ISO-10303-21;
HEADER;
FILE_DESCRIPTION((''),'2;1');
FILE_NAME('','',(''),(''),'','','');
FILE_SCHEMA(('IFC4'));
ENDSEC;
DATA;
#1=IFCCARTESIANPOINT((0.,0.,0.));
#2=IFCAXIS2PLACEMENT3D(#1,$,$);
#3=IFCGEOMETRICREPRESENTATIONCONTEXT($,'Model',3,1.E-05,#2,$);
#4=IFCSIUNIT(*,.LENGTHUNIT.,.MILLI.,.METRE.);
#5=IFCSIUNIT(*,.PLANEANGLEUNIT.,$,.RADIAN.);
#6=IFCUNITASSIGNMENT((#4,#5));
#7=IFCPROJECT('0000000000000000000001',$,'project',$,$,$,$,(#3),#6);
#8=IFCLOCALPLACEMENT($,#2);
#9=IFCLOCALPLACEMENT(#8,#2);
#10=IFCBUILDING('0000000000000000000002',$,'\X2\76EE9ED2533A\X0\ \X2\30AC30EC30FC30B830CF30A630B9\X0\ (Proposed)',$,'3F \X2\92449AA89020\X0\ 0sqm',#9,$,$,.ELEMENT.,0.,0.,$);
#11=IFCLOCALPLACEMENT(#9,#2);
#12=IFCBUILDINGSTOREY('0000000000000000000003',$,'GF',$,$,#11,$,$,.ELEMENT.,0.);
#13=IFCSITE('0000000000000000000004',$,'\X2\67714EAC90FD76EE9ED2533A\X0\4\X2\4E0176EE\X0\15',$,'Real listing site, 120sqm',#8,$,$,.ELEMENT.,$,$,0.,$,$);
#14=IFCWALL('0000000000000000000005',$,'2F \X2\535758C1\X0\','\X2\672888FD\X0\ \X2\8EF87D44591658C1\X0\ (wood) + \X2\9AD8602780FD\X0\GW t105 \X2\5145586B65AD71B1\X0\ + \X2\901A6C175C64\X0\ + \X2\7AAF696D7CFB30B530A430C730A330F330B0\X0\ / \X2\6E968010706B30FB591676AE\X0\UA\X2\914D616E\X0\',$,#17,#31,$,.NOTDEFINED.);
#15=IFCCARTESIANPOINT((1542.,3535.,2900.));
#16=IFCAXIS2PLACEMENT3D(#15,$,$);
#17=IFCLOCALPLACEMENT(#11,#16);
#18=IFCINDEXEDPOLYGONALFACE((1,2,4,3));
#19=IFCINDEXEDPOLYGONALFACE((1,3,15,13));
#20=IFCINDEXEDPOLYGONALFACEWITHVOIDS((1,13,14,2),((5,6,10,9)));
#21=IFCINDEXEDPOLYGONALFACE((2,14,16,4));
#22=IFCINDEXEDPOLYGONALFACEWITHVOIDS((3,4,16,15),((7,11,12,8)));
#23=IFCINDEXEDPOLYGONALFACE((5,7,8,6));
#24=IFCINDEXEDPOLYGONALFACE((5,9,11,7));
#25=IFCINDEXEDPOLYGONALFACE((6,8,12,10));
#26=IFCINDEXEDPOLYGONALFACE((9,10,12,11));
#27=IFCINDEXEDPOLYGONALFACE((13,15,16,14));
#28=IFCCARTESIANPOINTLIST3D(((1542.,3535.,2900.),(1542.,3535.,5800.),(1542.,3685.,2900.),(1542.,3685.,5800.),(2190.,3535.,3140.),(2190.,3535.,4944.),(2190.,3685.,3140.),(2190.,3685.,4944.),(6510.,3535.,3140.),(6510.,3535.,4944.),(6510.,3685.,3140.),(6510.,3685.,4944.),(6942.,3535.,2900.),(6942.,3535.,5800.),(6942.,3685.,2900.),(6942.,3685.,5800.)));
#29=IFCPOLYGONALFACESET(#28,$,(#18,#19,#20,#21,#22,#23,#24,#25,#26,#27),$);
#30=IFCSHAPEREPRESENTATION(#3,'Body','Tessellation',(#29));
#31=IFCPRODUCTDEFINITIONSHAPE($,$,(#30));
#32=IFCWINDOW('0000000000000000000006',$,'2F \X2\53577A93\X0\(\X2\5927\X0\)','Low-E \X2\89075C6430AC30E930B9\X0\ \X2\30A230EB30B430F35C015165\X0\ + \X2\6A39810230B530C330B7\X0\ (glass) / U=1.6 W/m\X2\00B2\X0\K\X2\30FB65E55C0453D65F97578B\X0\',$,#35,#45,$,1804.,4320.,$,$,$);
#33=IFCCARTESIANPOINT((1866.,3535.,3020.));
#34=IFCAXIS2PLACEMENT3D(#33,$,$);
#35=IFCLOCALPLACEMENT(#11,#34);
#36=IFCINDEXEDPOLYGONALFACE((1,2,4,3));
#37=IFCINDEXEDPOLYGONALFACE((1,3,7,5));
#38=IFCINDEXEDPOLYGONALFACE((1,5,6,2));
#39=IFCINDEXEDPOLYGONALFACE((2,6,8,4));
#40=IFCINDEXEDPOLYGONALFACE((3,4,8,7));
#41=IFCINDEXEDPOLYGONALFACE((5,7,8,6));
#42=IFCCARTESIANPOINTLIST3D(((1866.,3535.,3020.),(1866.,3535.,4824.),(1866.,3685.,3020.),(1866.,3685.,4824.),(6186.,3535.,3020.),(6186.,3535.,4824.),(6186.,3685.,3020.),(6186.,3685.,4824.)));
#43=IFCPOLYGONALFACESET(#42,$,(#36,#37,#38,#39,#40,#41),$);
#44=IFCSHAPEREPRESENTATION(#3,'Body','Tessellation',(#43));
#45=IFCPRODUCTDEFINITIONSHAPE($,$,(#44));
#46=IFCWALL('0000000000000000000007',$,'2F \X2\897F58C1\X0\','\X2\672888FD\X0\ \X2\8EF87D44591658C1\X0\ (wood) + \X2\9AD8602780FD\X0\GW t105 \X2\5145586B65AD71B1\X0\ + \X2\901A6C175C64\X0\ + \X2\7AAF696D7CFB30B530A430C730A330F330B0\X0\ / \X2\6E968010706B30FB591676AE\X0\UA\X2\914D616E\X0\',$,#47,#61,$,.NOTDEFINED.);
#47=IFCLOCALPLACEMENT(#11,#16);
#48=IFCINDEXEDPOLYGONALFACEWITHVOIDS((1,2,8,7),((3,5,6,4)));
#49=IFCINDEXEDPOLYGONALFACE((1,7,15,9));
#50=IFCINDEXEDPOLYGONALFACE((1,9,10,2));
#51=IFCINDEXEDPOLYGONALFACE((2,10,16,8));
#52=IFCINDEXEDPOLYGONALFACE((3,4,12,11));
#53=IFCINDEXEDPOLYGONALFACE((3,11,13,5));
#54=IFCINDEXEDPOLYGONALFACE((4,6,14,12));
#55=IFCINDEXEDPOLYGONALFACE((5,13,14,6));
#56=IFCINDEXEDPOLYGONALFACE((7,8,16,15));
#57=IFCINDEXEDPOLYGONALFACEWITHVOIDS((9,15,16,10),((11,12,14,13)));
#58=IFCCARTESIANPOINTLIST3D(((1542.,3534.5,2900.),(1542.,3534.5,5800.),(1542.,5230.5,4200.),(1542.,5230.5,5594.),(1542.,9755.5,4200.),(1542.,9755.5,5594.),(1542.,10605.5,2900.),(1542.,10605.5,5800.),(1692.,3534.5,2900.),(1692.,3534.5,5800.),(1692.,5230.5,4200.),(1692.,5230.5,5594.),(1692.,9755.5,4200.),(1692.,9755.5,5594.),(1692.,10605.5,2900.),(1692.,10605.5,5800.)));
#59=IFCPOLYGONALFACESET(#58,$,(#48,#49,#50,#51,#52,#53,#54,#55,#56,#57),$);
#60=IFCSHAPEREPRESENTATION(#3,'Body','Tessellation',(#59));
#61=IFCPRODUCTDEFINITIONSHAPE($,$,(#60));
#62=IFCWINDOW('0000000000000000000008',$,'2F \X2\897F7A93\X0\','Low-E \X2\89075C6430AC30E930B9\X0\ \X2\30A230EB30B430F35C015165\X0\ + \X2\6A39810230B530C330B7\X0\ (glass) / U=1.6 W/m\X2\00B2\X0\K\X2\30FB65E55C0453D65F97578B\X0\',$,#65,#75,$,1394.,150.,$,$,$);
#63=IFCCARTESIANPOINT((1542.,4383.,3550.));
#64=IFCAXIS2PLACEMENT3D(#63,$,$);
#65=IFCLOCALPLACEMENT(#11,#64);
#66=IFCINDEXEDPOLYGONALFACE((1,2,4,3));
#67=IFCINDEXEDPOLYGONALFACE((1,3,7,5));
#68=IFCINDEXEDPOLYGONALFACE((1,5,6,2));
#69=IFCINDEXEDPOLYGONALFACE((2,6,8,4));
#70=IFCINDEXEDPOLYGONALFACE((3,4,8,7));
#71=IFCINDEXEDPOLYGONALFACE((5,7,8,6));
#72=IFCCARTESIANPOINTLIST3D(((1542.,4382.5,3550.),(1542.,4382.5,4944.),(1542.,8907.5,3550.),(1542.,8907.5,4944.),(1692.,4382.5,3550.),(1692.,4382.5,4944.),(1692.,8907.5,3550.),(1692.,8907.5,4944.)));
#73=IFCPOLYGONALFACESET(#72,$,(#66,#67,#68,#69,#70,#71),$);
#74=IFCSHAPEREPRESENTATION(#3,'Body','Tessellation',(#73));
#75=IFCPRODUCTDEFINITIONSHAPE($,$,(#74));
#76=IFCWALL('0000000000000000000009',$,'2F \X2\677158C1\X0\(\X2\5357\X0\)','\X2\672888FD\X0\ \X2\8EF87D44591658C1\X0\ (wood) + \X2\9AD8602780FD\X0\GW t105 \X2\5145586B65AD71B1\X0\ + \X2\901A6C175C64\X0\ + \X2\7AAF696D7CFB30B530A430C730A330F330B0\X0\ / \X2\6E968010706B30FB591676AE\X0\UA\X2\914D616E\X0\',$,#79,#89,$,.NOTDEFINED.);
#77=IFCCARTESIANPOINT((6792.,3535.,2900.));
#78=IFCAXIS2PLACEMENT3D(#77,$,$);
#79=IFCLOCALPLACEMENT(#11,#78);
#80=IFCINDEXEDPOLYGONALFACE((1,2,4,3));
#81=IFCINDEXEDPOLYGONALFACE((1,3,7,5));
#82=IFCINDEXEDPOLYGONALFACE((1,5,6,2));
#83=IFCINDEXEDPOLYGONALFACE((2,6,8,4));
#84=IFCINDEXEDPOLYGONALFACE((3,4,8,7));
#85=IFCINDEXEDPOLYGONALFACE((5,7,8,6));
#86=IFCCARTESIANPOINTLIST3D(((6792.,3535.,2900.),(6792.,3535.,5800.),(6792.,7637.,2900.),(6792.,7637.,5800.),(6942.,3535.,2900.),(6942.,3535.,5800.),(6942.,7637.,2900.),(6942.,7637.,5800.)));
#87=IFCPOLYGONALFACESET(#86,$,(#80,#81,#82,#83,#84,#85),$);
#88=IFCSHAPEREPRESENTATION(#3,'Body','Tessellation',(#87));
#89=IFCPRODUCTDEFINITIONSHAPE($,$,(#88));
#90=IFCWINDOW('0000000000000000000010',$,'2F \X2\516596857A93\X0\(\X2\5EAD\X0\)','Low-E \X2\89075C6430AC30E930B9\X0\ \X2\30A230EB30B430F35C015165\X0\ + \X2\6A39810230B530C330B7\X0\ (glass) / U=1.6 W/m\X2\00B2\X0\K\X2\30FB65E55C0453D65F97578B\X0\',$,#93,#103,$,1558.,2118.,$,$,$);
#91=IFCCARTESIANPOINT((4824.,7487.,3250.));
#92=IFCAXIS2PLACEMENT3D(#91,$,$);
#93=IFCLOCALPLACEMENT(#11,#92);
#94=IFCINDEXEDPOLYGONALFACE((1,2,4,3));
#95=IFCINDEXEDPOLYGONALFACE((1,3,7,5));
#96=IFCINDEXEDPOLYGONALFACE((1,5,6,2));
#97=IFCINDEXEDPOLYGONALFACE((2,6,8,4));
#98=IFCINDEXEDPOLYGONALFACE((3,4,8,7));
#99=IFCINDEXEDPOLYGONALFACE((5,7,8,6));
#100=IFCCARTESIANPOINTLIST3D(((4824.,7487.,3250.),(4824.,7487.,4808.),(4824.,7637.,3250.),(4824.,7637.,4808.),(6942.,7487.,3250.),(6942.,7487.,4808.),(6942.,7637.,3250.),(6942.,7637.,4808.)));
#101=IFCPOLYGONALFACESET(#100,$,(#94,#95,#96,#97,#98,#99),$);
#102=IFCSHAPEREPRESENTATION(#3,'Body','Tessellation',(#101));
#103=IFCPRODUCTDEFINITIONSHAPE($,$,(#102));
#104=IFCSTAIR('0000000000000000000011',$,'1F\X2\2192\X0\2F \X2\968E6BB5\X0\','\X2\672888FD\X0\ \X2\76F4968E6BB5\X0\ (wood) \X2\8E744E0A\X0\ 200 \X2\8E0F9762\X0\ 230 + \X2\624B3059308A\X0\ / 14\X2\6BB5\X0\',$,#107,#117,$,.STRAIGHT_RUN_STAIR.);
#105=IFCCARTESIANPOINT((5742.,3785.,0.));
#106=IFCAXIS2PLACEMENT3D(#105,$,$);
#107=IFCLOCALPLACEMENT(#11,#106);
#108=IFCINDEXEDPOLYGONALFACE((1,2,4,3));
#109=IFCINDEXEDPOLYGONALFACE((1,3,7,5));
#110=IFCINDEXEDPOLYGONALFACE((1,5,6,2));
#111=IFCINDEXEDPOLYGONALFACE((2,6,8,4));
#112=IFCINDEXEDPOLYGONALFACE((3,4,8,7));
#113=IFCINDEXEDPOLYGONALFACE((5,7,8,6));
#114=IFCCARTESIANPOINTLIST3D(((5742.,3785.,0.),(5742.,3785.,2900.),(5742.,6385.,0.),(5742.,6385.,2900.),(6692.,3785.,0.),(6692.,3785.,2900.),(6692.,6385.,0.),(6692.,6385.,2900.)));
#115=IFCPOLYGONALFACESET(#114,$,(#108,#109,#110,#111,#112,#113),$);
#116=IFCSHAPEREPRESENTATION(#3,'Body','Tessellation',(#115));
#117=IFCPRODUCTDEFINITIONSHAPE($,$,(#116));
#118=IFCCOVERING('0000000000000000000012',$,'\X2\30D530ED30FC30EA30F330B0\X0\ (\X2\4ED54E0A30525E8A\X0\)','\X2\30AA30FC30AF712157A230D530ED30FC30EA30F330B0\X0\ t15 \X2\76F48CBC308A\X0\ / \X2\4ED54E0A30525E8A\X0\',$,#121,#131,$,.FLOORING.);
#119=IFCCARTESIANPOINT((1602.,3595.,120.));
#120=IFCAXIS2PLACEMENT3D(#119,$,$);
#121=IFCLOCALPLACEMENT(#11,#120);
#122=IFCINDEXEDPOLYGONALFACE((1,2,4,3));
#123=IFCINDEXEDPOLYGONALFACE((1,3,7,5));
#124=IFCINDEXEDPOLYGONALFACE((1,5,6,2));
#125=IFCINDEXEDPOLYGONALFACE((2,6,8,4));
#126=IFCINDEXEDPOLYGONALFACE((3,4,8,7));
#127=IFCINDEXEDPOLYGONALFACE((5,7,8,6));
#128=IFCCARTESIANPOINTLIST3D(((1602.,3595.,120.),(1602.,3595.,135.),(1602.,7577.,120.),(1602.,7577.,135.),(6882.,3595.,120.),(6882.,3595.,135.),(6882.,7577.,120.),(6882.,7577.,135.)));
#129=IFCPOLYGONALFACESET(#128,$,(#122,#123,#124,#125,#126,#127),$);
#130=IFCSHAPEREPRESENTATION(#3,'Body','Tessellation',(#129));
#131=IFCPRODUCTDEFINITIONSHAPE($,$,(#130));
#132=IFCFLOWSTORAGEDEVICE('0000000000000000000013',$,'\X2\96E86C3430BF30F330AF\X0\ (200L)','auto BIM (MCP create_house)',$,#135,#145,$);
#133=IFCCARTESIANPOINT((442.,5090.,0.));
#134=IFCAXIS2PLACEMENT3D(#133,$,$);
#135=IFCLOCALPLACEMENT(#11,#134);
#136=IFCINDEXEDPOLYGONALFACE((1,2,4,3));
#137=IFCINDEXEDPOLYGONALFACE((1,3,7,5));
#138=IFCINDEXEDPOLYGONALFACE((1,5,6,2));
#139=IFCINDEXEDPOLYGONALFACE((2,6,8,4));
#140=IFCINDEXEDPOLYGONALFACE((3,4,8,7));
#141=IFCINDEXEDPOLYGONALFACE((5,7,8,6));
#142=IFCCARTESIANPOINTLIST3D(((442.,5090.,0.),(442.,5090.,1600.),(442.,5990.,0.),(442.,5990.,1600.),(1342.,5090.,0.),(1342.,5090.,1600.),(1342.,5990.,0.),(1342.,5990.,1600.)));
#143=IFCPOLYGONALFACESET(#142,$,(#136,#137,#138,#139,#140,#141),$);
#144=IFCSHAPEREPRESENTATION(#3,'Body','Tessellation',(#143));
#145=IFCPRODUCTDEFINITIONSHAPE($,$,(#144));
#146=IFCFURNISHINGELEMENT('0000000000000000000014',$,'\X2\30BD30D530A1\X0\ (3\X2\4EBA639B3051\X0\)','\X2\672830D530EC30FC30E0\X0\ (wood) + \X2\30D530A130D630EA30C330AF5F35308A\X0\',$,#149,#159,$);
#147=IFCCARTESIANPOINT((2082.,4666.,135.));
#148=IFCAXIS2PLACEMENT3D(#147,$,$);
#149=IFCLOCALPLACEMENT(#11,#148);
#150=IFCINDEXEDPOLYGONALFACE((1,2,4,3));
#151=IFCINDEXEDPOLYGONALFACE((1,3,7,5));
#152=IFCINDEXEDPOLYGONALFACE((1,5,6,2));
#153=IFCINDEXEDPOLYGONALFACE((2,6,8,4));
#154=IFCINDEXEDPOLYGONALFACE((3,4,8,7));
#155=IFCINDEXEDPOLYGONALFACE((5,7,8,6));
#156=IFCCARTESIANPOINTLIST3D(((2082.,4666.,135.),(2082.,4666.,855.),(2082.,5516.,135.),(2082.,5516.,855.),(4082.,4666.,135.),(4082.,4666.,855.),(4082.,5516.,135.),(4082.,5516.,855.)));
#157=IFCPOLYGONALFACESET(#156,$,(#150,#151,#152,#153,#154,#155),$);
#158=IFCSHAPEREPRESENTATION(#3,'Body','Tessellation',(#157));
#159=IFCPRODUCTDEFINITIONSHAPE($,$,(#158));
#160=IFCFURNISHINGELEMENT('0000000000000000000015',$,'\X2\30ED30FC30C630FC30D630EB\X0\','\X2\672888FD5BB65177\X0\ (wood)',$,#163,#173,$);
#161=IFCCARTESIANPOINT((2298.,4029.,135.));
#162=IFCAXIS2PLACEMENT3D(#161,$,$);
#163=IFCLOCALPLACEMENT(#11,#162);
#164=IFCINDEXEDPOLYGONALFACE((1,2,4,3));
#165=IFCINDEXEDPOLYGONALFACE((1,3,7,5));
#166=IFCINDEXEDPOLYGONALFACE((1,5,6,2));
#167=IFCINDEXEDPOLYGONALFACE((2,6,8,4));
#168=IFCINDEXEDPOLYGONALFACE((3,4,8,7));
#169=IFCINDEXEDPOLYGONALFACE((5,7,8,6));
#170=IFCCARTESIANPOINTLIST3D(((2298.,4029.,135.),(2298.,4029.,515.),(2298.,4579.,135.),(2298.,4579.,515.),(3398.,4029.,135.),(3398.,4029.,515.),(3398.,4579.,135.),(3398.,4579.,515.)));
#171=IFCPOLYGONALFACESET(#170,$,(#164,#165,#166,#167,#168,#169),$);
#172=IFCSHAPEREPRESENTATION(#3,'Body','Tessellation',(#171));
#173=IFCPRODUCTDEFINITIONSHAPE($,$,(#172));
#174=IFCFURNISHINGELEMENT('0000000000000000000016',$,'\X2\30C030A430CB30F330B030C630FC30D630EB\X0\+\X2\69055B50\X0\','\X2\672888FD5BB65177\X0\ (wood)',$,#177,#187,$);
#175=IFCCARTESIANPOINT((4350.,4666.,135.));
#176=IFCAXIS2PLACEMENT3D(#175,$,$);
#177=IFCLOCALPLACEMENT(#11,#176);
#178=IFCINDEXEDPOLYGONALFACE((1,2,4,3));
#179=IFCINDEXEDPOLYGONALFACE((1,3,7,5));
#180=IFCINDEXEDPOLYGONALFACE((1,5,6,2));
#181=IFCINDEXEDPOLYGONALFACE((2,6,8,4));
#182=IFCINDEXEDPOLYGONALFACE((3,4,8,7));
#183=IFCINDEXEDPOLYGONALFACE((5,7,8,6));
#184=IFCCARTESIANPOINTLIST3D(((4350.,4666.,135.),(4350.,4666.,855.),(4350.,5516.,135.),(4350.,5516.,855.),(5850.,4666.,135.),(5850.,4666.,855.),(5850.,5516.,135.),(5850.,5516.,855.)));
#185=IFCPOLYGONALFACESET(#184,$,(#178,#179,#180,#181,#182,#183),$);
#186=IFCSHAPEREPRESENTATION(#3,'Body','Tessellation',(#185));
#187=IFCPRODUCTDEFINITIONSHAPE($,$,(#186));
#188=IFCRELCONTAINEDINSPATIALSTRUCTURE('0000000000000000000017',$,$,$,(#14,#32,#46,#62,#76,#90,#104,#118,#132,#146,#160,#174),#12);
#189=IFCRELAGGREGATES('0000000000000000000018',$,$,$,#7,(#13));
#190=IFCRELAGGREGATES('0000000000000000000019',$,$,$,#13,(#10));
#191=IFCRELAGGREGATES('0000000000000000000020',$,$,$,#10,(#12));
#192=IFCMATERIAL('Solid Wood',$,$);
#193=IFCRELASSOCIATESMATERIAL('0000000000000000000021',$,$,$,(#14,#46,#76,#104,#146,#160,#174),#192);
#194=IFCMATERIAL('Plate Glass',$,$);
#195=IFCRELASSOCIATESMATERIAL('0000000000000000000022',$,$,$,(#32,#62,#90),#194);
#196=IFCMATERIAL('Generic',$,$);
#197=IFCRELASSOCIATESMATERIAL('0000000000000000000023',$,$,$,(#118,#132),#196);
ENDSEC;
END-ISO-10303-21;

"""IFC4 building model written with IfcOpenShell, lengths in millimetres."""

from ifc_helpers import new_model, si_unit, frame, frame_2d, origin, place, context, project, spatial, rectangle, extrude, material, element, fill, save


model = new_model("IFC4")

# Units and contexts
model_context = context("Model", 3, precision=1e-05, world=origin())
ifc_project = project(units=[si_unit("LENGTHUNIT", "METRE", prefix="MILLI"), si_unit("PLANEANGLEUNIT", "RADIAN")], contexts=[model_context])

# Site, building, storey
site_placement = place(None, origin())
site = spatial("IfcSite", under=ifc_project, at=site_placement, Name="東京都目黒区4丁目15", ObjectType="Real listing site, 120sqm", CompositionType="ELEMENT", RefElevation=0.0)
building_placement = place(site_placement, origin())
building = spatial("IfcBuilding", under=site, at=building_placement, Name="目黒区 ガレージハウス (Proposed)", ObjectType="3F 鉄骨造 0sqm", CompositionType="ELEMENT", ElevationOfRefHeight=0.0, ElevationOfTerrain=0.0)
storey_placement = place(building_placement, origin())
storey = spatial("IfcBuildingStorey", under=building, at=storey_placement, Name="GF", CompositionType="ELEMENT", Elevation=0.0)

# Shared definitions
ifc_material_1 = material(Name="Solid Wood")

# Shared definitions
ifc_material_2 = material(Name="Plate Glass")

# Walls, openings, windows
wall_1_placement = place(storey_placement, frame((1542.0, 3535.0, 2900.0)))
wall_1 = element("IfcWall", 1, at=wall_1_placement, inside=storey, material=ifc_material_1, Name="2F 南壁", Description="木製 軸組外壁 (wood) + 高性能GW t105 充填断熱 + 通気層 + 窯業系サイディング / 準耐火・外皮UA配慮", PredefinedType="NOTDEFINED", context=model_context, shape_type="SweptSolid", body=[
    extrude(rectangle(XDim=5400.0, YDim=150.0, at=frame_2d((2700.0, 75.0))), frame((1542.0, 3535.0, 2900.0)), (0.0, 0.0, 1.0), 2900.0),
])
opening_1_placement = place(storey_placement, frame((1866.0, 3535.0, 3020.0)))
opening_1 = element("IfcOpeningElement", 2, at=opening_1_placement, cuts=wall_1, PredefinedType="NOTDEFINED", context=model_context, shape_type="SweptSolid", body=[
    extrude(rectangle(XDim=4320.0, YDim=150.0, at=frame_2d((2160.0, 75.0))), frame((1866.0, 3535.0, 3020.0)), (0.0, 0.0, 1.0), 1804.0),
])
window_1_placement = place(storey_placement, frame((1866.0, 3535.0, 3020.0)))
window_1 = element("IfcWindow", 3, at=window_1_placement, inside=storey, material=ifc_material_2, Name="2F 南窓(大)", Description="Low-E 複層ガラス アルゴン封入 + 樹脂サッシ (glass) / U=1.6 W/m²K・日射取得型", OverallHeight=1804.0, OverallWidth=4320.0, context=model_context, shape_type="SweptSolid", body=[
    extrude(rectangle(XDim=4320.0, YDim=150.0, at=frame_2d((2160.0, 75.0))), frame((1866.0, 3535.0, 3020.0)), (0.0, 0.0, 1.0), 1804.0),
])
fill(opening_1, window_1)
wall_2_placement = place(storey_placement, frame((1542.0, 3535.0, 2900.0)))
wall_2 = element("IfcWall", 4, at=wall_2_placement, inside=storey, material=ifc_material_1, Name="2F 西壁", Description="木製 軸組外壁 (wood) + 高性能GW t105 充填断熱 + 通気層 + 窯業系サイディング / 準耐火・外皮UA配慮", PredefinedType="NOTDEFINED", context=model_context, shape_type="SweptSolid", body=[
    extrude(rectangle(XDim=150.0, YDim=7071.0, at=frame_2d((75.0, 3535.0))), frame((1542.0, 3535.0, 2900.0)), (0.0, 0.0, 1.0), 2900.0),
])
opening_2_placement = place(storey_placement, frame((1542.0, 4383.0, 3550.0)))
opening_2 = element("IfcOpeningElement", 5, at=opening_2_placement, cuts=wall_2, PredefinedType="NOTDEFINED", context=model_context, shape_type="SweptSolid", body=[
    extrude(rectangle(XDim=150.0, YDim=4525.0, at=frame_2d((75.0, 2262.0))), frame((1542.0, 4383.0, 3550.0)), (0.0, 0.0, 1.0), 1394.0),
])
window_2_placement = place(storey_placement, frame((1542.0, 4383.0, 3550.0)))
window_2 = element("IfcWindow", 6, at=window_2_placement, inside=storey, material=ifc_material_2, Name="2F 西窓", Description="Low-E 複層ガラス アルゴン封入 + 樹脂サッシ (glass) / U=1.6 W/m²K・日射取得型", OverallHeight=1394.0, OverallWidth=150.0, context=model_context, shape_type="SweptSolid", body=[
    extrude(rectangle(XDim=150.0, YDim=4525.0, at=frame_2d((75.0, 2262.0))), frame((1542.0, 4383.0, 3550.0)), (0.0, 0.0, 1.0), 1394.0),
])
fill(opening_2, window_2)
wall_3_placement = place(storey_placement, frame((6792.0, 3535.0, 2900.0)))
wall_3 = element("IfcWall", 7, at=wall_3_placement, inside=storey, material=ifc_material_1, Name="2F 東壁(南)", Description="木製 軸組外壁 (wood) + 高性能GW t105 充填断熱 + 通気層 + 窯業系サイディング / 準耐火・外皮UA配慮", PredefinedType="NOTDEFINED", context=model_context, shape_type="SweptSolid", body=[
    extrude(rectangle(XDim=150.0, YDim=4102.0, at=frame_2d((75.0, 2051.0))), frame((6792.0, 3535.0, 2900.0)), (0.0, 0.0, 1.0), 2900.0),
])
opening_3_placement = place(storey_placement, frame((4824.0, 7487.0, 3250.0)))
opening_3 = element("IfcOpeningElement", 8, at=opening_3_placement, cuts=wall_3, PredefinedType="NOTDEFINED", context=model_context, shape_type="SweptSolid", body=[
    extrude(rectangle(XDim=2118.0, YDim=150.0, at=frame_2d((1059.0, 75.0))), frame((4824.0, 7487.0, 3250.0)), (0.0, 0.0, 1.0), 1558.0),
])
window_3_placement = place(storey_placement, frame((4824.0, 7487.0, 3250.0)))
window_3 = element("IfcWindow", 9, at=window_3_placement, inside=storey, material=ifc_material_2, Name="2F 入隅窓(庭)", Description="Low-E 複層ガラス アルゴン封入 + 樹脂サッシ (glass) / U=1.6 W/m²K・日射取得型", OverallHeight=1558.0, OverallWidth=2118.0, context=model_context, shape_type="SweptSolid", body=[
    extrude(rectangle(XDim=2118.0, YDim=150.0, at=frame_2d((1059.0, 75.0))), frame((4824.0, 7487.0, 3250.0)), (0.0, 0.0, 1.0), 1558.0),
])
fill(opening_3, window_3)

# Stair
stair_placement = place(storey_placement, frame((5742.0, 3785.0, 0.0)))
element("IfcStair", 10, at=stair_placement, inside=storey, material=ifc_material_1, Name="1F→2F 階段", Description="木製 直階段 (wood) 蹴上 200 踏面 230 + 手すり / 14段", PredefinedType="STRAIGHT_RUN_STAIR", context=model_context, shape_type="SweptSolid", body=[
    extrude(rectangle(XDim=950.0, YDim=2600.0, at=frame_2d((475.0, 1300.0))), frame((5742.0, 3785.0, 0.0)), (0.0, 0.0, 1.0), 2900.0),
])

# Covering
ifc_material_3 = material(Name="Generic")
covering_placement = place(storey_placement, frame((1602.0, 3595.0, 120.0)))
element("IfcCovering", 11, at=covering_placement, inside=storey, material=ifc_material_3, Name="フローリング (仕上げ床)", Description="オーク無垢フローリング t15 直貼り / 仕上げ床", PredefinedType="FLOORING", context=model_context, shape_type="SweptSolid", body=[
    extrude(rectangle(XDim=5280.0, YDim=3982.0, at=frame_2d((2640.0, 1991.0))), frame((1602.0, 3595.0, 120.0)), (0.0, 0.0, 1.0), 15.0),
])

# Flow storage device
flow_storage_device_placement = place(storey_placement, frame((442.0, 5090.0, 0.0)))
element("IfcFlowStorageDevice", 12, at=flow_storage_device_placement, inside=storey, material=ifc_material_3, Name="雨水タンク (200L)", Description="auto BIM (MCP create_house)", context=model_context, shape_type="SweptSolid", body=[
    extrude(rectangle(XDim=900.0, YDim=900.0, at=frame_2d((450.0, 450.0))), frame((442.0, 5090.0, 0.0)), (0.0, 0.0, 1.0), 1600.0),
])

# Furnishing elements
furnishing_1_placement = place(storey_placement, frame((2082.0, 4666.0, 135.0)))
element("IfcFurnishingElement", 13, at=furnishing_1_placement, inside=storey, material=ifc_material_1, Name="ソファ (3人掛け)", Description="木フレーム (wood) + ファブリック張り", context=model_context, shape_type="SweptSolid", body=[
    extrude(rectangle(XDim=2000.0, YDim=850.0, at=frame_2d((1000.0, 425.0))), frame((2082.0, 4666.0, 135.0)), (0.0, 0.0, 1.0), 720.0),
])
furnishing_2_placement = place(storey_placement, frame((2298.0, 4029.0, 135.0)))
element("IfcFurnishingElement", 14, at=furnishing_2_placement, inside=storey, material=ifc_material_1, Name="ローテーブル", Description="木製家具 (wood)", context=model_context, shape_type="SweptSolid", body=[
    extrude(rectangle(XDim=1100.0, YDim=550.0, at=frame_2d((550.0, 275.0))), frame((2298.0, 4029.0, 135.0)), (0.0, 0.0, 1.0), 380.0),
])
furnishing_3_placement = place(storey_placement, frame((4350.0, 4666.0, 135.0)))
element("IfcFurnishingElement", 15, at=furnishing_3_placement, inside=storey, material=ifc_material_1, Name="ダイニングテーブル+椅子", Description="木製家具 (wood)", context=model_context, shape_type="SweptSolid", body=[
    extrude(rectangle(XDim=1500.0, YDim=850.0, at=frame_2d((750.0, 425.0))), frame((4350.0, 4666.0, 135.0)), (0.0, 0.0, 1.0), 720.0),
])

save(model, "model.ifc")
